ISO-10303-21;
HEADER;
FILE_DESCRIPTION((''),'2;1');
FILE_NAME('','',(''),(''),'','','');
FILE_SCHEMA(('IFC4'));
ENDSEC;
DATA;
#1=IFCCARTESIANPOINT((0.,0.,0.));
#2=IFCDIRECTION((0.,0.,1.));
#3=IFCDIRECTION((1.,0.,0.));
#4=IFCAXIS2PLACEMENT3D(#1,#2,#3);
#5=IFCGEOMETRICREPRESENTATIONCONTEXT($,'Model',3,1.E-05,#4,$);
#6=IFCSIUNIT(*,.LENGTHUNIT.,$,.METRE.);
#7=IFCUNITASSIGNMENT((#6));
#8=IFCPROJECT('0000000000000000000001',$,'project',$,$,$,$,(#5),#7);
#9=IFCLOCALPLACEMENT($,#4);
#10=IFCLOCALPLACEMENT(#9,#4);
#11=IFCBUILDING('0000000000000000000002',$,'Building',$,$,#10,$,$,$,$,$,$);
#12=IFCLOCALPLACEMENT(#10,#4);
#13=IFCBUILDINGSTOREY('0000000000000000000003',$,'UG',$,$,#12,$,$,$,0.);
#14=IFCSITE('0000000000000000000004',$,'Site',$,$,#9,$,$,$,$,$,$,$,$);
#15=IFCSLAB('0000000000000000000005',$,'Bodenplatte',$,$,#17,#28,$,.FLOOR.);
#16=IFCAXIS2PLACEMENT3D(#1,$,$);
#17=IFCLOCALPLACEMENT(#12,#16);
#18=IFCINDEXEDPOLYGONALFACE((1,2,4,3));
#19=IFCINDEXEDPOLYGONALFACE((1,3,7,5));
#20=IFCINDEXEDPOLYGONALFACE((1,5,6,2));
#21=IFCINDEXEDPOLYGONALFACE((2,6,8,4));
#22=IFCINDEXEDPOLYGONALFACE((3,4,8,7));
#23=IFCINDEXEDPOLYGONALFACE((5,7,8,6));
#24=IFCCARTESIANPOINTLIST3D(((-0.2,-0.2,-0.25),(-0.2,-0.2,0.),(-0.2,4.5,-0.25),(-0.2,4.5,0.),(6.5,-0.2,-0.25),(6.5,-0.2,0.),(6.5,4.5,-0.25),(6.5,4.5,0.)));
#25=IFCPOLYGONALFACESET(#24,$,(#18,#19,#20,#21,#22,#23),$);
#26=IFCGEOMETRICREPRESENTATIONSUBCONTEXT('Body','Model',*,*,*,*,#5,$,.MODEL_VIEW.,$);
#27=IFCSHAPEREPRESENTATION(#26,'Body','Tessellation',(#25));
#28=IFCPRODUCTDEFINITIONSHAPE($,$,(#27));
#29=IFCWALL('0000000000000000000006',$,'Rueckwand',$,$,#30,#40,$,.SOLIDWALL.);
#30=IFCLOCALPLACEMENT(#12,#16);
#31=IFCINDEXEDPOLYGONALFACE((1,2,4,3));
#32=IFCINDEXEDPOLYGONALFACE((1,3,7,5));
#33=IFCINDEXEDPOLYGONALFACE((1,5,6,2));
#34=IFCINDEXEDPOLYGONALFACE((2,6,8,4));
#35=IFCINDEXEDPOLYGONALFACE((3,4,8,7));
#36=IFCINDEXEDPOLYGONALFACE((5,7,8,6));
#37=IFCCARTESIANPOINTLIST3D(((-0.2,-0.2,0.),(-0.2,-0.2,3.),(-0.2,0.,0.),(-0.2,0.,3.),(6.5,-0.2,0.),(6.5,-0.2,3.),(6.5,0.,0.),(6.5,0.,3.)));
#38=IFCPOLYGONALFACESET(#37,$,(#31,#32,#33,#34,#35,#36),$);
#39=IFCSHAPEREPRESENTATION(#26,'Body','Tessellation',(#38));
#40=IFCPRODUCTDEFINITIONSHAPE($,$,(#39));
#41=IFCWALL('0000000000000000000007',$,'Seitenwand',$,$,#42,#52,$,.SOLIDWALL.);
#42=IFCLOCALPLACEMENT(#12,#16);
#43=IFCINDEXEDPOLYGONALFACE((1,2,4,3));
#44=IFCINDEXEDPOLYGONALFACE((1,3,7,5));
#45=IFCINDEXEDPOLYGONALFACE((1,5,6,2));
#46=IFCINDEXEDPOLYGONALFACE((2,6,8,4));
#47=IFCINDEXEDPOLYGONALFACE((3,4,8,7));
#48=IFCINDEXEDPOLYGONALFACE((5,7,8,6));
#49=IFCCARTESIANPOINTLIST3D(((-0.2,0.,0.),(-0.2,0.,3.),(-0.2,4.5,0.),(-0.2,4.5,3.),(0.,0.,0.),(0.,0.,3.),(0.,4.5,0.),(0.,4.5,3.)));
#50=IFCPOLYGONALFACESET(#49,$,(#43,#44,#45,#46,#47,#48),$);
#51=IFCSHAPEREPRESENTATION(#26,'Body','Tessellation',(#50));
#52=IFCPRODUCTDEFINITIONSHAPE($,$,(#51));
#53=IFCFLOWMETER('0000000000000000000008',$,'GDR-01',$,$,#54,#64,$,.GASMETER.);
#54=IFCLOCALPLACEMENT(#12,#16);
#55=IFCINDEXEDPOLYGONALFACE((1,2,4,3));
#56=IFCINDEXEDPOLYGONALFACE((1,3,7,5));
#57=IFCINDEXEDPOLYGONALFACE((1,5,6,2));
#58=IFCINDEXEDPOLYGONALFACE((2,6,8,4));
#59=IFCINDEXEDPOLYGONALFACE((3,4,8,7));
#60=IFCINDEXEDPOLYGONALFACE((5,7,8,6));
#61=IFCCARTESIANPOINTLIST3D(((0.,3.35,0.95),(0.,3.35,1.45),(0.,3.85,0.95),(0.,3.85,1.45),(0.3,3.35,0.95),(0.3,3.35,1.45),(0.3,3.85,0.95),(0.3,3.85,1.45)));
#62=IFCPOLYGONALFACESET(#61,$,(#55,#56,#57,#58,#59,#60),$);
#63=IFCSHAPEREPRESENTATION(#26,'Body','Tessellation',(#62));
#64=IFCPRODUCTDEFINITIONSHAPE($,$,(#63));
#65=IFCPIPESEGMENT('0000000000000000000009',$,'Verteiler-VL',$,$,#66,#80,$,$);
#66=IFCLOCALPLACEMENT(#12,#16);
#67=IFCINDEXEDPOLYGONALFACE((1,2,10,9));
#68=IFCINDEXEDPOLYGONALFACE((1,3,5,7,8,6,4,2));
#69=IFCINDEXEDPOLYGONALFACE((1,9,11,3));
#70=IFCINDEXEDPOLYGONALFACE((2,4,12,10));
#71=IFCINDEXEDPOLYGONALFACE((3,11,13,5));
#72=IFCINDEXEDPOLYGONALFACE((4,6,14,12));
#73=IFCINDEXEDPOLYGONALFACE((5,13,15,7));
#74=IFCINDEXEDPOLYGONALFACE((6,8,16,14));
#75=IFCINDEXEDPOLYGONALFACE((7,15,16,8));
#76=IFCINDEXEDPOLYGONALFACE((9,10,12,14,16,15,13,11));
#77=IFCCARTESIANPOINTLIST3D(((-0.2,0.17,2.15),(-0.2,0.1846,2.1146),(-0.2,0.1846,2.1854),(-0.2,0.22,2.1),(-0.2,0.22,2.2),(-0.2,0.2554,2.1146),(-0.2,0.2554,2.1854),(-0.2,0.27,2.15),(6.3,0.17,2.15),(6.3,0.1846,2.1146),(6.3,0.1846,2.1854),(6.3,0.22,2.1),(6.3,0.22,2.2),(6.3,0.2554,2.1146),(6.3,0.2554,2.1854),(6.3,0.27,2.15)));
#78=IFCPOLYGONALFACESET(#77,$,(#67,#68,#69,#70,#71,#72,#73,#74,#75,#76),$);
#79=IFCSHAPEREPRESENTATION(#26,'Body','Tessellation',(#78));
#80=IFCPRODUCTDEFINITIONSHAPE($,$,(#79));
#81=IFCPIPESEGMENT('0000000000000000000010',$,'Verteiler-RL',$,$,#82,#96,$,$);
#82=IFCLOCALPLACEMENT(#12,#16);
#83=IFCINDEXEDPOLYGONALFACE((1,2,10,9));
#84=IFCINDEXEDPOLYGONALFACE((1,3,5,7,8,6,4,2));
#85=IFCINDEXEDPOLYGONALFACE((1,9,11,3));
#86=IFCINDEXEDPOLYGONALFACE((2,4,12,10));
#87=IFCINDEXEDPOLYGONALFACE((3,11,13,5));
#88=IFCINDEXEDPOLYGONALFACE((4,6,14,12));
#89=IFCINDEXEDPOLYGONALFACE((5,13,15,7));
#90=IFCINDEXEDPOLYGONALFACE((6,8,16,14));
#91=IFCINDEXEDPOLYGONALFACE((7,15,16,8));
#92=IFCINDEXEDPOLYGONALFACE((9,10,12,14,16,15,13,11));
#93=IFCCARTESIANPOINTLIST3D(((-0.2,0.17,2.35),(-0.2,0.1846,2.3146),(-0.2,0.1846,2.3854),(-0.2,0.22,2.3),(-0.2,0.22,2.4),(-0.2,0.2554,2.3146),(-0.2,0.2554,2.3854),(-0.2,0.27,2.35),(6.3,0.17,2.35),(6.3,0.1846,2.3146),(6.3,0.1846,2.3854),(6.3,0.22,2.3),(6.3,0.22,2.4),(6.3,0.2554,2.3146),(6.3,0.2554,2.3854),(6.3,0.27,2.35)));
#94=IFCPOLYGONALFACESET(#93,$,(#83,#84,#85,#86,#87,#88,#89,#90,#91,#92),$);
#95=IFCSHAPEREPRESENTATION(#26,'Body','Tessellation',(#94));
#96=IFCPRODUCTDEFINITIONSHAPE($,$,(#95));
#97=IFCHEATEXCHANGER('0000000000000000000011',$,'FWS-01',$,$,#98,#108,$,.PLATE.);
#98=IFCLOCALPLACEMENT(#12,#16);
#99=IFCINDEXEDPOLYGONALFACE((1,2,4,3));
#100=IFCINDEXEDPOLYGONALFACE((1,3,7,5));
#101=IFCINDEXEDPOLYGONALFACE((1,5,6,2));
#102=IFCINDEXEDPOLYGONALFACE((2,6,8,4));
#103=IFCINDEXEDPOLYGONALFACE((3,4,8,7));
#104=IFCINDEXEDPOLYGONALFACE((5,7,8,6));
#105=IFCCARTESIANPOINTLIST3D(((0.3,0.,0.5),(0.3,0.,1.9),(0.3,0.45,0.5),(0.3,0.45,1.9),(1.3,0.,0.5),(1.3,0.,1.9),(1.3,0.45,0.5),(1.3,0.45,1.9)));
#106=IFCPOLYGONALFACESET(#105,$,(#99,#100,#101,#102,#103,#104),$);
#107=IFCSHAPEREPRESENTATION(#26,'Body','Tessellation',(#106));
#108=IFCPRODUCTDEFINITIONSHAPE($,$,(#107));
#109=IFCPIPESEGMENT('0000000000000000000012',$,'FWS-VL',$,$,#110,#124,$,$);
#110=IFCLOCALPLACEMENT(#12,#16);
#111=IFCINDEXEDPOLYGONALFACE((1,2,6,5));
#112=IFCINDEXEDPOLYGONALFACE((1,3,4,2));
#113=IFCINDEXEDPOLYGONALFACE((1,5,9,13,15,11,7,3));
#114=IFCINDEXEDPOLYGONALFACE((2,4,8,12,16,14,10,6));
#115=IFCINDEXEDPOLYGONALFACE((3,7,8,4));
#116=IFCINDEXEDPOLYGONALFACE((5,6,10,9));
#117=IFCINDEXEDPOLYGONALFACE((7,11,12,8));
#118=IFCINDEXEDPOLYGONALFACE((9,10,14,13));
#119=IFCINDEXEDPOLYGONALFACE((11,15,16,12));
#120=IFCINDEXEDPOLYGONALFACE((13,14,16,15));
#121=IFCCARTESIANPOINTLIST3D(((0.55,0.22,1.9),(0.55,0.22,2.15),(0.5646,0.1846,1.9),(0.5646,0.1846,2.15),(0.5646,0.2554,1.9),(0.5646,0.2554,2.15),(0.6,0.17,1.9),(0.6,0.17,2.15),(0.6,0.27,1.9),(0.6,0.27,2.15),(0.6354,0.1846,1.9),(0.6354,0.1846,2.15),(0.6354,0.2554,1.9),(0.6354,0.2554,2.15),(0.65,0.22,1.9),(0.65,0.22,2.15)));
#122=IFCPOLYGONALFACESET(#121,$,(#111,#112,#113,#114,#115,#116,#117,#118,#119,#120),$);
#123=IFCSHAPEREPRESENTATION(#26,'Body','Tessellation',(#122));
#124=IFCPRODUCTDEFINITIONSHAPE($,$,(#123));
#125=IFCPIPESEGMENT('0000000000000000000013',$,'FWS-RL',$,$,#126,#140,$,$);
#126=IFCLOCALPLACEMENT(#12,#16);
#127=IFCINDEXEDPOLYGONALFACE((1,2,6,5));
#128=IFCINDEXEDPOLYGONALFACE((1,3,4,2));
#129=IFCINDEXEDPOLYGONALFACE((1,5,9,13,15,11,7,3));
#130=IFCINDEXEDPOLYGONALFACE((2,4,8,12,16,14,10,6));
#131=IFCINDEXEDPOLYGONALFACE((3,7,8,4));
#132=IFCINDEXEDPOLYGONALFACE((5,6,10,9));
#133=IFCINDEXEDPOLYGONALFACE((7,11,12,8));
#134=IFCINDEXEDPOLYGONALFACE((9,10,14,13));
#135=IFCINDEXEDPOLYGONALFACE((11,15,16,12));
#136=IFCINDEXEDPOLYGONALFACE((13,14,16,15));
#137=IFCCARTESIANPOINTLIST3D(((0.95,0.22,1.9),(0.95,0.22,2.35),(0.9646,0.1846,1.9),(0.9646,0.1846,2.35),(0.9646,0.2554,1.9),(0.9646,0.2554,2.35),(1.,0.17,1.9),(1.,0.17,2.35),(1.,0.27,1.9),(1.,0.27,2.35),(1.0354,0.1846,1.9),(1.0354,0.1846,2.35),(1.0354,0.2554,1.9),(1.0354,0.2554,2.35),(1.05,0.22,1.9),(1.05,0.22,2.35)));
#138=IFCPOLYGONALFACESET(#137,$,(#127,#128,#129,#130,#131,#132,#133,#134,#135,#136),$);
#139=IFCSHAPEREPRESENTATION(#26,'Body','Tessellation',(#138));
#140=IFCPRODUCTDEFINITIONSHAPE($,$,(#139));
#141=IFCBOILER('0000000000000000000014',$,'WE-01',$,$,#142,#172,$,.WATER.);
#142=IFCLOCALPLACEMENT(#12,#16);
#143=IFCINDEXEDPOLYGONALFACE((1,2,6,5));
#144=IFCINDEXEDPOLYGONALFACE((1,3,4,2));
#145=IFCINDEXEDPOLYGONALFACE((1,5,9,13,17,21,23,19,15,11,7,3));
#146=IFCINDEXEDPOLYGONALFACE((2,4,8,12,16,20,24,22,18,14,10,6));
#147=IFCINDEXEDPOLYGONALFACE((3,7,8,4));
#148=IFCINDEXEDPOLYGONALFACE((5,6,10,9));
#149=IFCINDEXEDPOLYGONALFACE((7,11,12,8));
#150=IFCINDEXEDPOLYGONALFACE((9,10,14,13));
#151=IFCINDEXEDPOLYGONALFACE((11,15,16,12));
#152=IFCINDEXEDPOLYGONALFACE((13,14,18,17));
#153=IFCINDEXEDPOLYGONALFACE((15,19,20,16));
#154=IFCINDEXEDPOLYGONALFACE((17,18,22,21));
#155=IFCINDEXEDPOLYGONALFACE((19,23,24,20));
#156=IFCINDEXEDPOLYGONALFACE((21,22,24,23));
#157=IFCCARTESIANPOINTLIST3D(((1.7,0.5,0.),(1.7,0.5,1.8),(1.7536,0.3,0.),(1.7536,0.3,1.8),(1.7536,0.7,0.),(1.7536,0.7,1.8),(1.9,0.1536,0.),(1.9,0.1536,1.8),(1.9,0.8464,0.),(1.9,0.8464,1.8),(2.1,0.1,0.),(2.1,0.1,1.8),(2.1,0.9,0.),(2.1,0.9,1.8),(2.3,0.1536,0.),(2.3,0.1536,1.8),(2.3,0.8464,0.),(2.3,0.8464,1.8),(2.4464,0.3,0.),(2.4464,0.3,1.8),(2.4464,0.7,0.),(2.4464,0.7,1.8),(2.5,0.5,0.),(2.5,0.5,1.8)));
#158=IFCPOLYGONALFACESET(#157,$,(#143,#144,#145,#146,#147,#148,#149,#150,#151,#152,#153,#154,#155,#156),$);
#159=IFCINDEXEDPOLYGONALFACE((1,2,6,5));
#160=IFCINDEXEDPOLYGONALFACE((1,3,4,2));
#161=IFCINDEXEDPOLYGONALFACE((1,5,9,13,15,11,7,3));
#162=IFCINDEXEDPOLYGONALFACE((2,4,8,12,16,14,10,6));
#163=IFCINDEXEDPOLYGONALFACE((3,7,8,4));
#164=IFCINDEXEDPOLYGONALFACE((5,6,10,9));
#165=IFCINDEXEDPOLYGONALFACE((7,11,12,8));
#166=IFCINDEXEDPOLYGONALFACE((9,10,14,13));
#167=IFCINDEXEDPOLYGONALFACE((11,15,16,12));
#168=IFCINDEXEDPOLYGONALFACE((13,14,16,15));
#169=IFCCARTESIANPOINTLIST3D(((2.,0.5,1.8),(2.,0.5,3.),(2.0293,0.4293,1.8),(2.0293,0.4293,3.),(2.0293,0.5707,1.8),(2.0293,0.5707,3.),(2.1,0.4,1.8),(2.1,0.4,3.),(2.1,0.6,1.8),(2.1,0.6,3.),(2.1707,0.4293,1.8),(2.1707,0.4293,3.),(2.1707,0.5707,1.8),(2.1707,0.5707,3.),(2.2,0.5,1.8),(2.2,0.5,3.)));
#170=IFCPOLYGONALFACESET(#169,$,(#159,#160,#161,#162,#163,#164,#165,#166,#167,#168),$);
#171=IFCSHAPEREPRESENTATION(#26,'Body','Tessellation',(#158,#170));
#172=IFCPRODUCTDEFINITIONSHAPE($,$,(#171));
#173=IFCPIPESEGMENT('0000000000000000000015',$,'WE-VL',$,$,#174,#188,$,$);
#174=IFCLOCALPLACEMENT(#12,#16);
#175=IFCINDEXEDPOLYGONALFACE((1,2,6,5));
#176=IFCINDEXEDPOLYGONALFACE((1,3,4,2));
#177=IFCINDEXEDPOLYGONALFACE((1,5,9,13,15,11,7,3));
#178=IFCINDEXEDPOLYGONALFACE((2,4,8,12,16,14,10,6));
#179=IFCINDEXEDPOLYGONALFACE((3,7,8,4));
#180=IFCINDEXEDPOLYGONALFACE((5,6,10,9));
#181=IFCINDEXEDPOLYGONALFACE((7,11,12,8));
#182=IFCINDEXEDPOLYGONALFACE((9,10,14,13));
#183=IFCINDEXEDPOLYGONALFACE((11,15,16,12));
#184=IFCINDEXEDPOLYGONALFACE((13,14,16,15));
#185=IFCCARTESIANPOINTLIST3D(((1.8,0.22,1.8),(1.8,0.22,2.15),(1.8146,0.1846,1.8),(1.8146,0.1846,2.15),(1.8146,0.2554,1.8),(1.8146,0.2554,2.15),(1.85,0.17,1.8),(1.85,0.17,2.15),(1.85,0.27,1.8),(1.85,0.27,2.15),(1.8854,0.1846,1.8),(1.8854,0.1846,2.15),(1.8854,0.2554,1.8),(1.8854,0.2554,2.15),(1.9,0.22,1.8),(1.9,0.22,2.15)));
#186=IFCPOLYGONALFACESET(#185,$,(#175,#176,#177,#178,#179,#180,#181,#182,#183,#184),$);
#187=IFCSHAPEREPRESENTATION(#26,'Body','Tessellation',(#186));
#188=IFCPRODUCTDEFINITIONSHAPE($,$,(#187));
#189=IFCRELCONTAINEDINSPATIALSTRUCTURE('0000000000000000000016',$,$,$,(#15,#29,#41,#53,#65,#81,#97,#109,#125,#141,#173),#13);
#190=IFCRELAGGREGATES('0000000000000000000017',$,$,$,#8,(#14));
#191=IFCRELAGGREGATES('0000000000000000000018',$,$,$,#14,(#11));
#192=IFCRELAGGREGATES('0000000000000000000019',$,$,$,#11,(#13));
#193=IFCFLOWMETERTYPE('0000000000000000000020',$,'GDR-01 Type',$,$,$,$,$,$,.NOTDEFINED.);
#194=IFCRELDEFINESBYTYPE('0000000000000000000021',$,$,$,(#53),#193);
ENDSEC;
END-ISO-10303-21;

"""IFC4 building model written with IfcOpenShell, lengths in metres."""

from ifc_helpers import new_model, si_unit, frame, origin_with_axes, place, context, subcontext, project, spatial, polyline, outline, extrude, type_object, element, save


model = new_model("IFC4")

# Units and contexts
model_context = context("Model", 3, precision=1e-05, world=origin_with_axes())
body_context = subcontext(model_context, "Body", "Model", "MODEL_VIEW")
ifc_project = project(units=[si_unit("LENGTHUNIT", "METRE")], contexts=[model_context])

# Site, building, storey
site_placement = place(None, origin_with_axes())
site = spatial("IfcSite", under=ifc_project, at=site_placement, Name="Site")
building_placement = place(site_placement, origin_with_axes())
building = spatial("IfcBuilding", under=site, at=building_placement, Name="Building")
storey_placement = place(building_placement, origin_with_axes())
storey = spatial("IfcBuildingStorey", under=building, at=storey_placement, Name="UG", Elevation=0.0)

# Slab
slab_placement = place(storey_placement, frame((0.0, 0.0, -0.25), z_axis=(0.0, 0.0, 1.0), x_axis=(1.0, 0.0, 0.0)))
element("IfcSlab", 1, at=slab_placement, inside=storey, Name="Bodenplatte", PredefinedType="FLOOR", context=body_context, shape_type="SweptSolid", body=[
    extrude(outline(polyline([(-0.2, -0.2, 0.0), (6.5, -0.2, 0.0), (6.5, 4.5, 0.0), (-0.2, 4.5, 0.0), (-0.2, -0.2, 0.0)])), origin_with_axes(), (0.0, 0.0, 1.0), 0.25),
])

# Walls
wall_1_placement = place(storey_placement, frame((-0.2, -0.2, 0.0), z_axis=(0.0, 0.0, 1.0), x_axis=(1.0, 0.0, 0.0)))
element("IfcWall", 2, at=wall_1_placement, inside=storey, Name="Rueckwand", PredefinedType="SOLIDWALL", context=body_context, shape_type="SweptSolid", body=[
    extrude(outline(polyline([(0.0, 0.0, 0.0), (6.7, 0.0, 0.0), (6.7, 0.2, 0.0), (0.0, 0.2, 0.0), (0.0, 0.0, 0.0)])), origin_with_axes(), (0.0, 0.0, 1.0), 3.0),
])
wall_2_placement = place(storey_placement, frame((0.0, 0.0, 0.0), z_axis=(0.0, 0.0, 1.0), x_axis=(0.0, 1.0, 0.0)))
element("IfcWall", 3, at=wall_2_placement, inside=storey, Name="Seitenwand", PredefinedType="SOLIDWALL", context=body_context, shape_type="SweptSolid", body=[
    extrude(outline(polyline([(0.0, 0.0, 0.0), (4.5, 0.0, 0.0), (4.5, 0.2, 0.0), (0.0, 0.2, 0.0), (0.0, 0.0, 0.0)])), origin_with_axes(), (0.0, 0.0, 1.0), 3.0),
])

# Flow meter
flow_meter_type = type_object("IfcFlowMeterType", Name="GDR-01 Type", PredefinedType="NOTDEFINED")
flow_meter_placement = place(storey_placement, origin_with_axes())
element("IfcFlowMeter", 4, at=flow_meter_placement, inside=storey, type_object=flow_meter_type, Name="GDR-01", PredefinedType="GASMETER", context=body_context, shape_type="SweptSolid", body=[
    extrude(outline(polyline([(0.0, 3.35, 0.0), (0.3, 3.35, 0.0), (0.3, 3.85, 0.0), (0.0, 3.85, 0.0), (0.0, 3.35, 0.0)])), frame((0.0, 0.0, 0.95), z_axis=(0.0, 0.0, 1.0), x_axis=(1.0, 0.0, 0.0)), (0.0, 0.0, 1.0), 0.5),
])

# Pipe segments
pipe_segment_1_placement = place(storey_placement, origin_with_axes())
element("IfcPipeSegment", 5, at=pipe_segment_1_placement, inside=storey, Name="Verteiler-VL", context=body_context, shape_type="SweptSolid", body=[
    extrude(outline(polyline([(0.05, 0.0, 0.0), (0.0354, 0.0354, 0.0), (0.0, 0.05, 0.0), (-0.0354, 0.0354, 0.0), (-0.05, 0.0, 0.0), (-0.0354, -0.0354, 0.0), (0.0, -0.05, 0.0), (0.0354, -0.0354, 0.0), (0.05, 0.0, 0.0)])), frame((-0.2, 0.22, 2.15), z_axis=(1.0, 0.0, 0.0), x_axis=(0.0, 1.0, 0.0)), (0.0, 0.0, 1.0), 6.5),
])
pipe_segment_2_placement = place(storey_placement, origin_with_axes())
element("IfcPipeSegment", 6, at=pipe_segment_2_placement, inside=storey, Name="Verteiler-RL", context=body_context, shape_type="SweptSolid", body=[
    extrude(outline(polyline([(0.05, 0.0, 0.0), (0.0354, 0.0354, 0.0), (0.0, 0.05, 0.0), (-0.0354, 0.0354, 0.0), (-0.05, 0.0, 0.0), (-0.0354, -0.0354, 0.0), (0.0, -0.05, 0.0), (0.0354, -0.0354, 0.0), (0.05, 0.0, 0.0)])), frame((-0.2, 0.22, 2.35), z_axis=(1.0, 0.0, 0.0), x_axis=(0.0, 1.0, 0.0)), (0.0, 0.0, 1.0), 6.5),
])

# Heat exchanger
heat_exchanger_placement = place(storey_placement, origin_with_axes())
element("IfcHeatExchanger", 7, at=heat_exchanger_placement, inside=storey, Name="FWS-01", PredefinedType="PLATE", context=body_context, shape_type="SweptSolid", body=[
    extrude(outline(polyline([(0.3, 0.0, 0.0), (1.3, 0.0, 0.0), (1.3, 0.45, 0.0), (0.3, 0.45, 0.0), (0.3, 0.0, 0.0)])), frame((0.0, 0.0, 0.5), z_axis=(0.0, 0.0, 1.0), x_axis=(1.0, 0.0, 0.0)), (0.0, 0.0, 1.0), 1.4),
])

# Pipe segments
pipe_segment_3_placement = place(storey_placement, origin_with_axes())
element("IfcPipeSegment", 8, at=pipe_segment_3_placement, inside=storey, Name="FWS-VL", context=body_context, shape_type="SweptSolid", body=[
    extrude(outline(polyline([(0.05, 0.0, 0.0), (0.0354, 0.0354, 0.0), (0.0, 0.05, 0.0), (-0.0354, 0.0354, 0.0), (-0.05, 0.0, 0.0), (-0.0354, -0.0354, 0.0), (0.0, -0.05, 0.0), (0.0354, -0.0354, 0.0), (0.05, 0.0, 0.0)])), frame((0.6, 0.22, 1.9), z_axis=(0.0, 0.0, 1.0), x_axis=(1.0, 0.0, 0.0)), (0.0, 0.0, 1.0), 0.25),
])
pipe_segment_4_placement = place(storey_placement, origin_with_axes())
element("IfcPipeSegment", 9, at=pipe_segment_4_placement, inside=storey, Name="FWS-RL", context=body_context, shape_type="SweptSolid", body=[
    extrude(outline(polyline([(0.05, 0.0, 0.0), (0.0354, 0.0354, 0.0), (0.0, 0.05, 0.0), (-0.0354, 0.0354, 0.0), (-0.05, 0.0, 0.0), (-0.0354, -0.0354, 0.0), (0.0, -0.05, 0.0), (0.0354, -0.0354, 0.0), (0.05, 0.0, 0.0)])), frame((1.0, 0.22, 1.9), z_axis=(0.0, 0.0, 1.0), x_axis=(1.0, 0.0, 0.0)), (0.0, 0.0, 1.0), 0.45),
])

# Boiler
boiler_placement = place(storey_placement, origin_with_axes())
element("IfcBoiler", 10, at=boiler_placement, inside=storey, Name="WE-01", PredefinedType="WATER", context=body_context, shape_type="SweptSolid", body=[
    extrude(outline(polyline([(0.4, 0.0, 0.0), (0.3464, 0.2, 0.0), (0.2, 0.3464, 0.0), (0.0, 0.4, 0.0), (-0.2, 0.3464, 0.0), (-0.3464, 0.2, 0.0), (-0.4, 0.0, 0.0), (-0.3464, -0.2, 0.0), (-0.2, -0.3464, 0.0), (0.0, -0.4, 0.0), (0.2, -0.3464, 0.0), (0.3464, -0.2, 0.0), (0.4, 0.0, 0.0)])), frame((2.1, 0.5, 0.0), z_axis=(0.0, 0.0, 1.0), x_axis=(1.0, 0.0, 0.0)), (0.0, 0.0, 1.0), 1.8),
    extrude(outline(polyline([(0.1, 0.0, 0.0), (0.0707, 0.0707, 0.0), (0.0, 0.1, 0.0), (-0.0707, 0.0707, 0.0), (-0.1, 0.0, 0.0), (-0.0707, -0.0707, 0.0), (0.0, -0.1, 0.0), (0.0707, -0.0707, 0.0), (0.1, 0.0, 0.0)])), frame((2.1, 0.5, 1.8), z_axis=(0.0, 0.0, 1.0), x_axis=(1.0, 0.0, 0.0)), (0.0, 0.0, 1.0), 1.2),
])

# Pipe segment
pipe_segment_5_placement = place(storey_placement, origin_with_axes())
element("IfcPipeSegment", 11, at=pipe_segment_5_placement, inside=storey, Name="WE-VL", context=body_context, shape_type="SweptSolid", body=[
    extrude(outline(polyline([(0.05, 0.0, 0.0), (0.0354, 0.0354, 0.0), (0.0, 0.05, 0.0), (-0.0354, 0.0354, 0.0), (-0.05, 0.0, 0.0), (-0.0354, -0.0354, 0.0), (0.0, -0.05, 0.0), (0.0354, -0.0354, 0.0), (0.05, 0.0, 0.0)])), frame((1.85, 0.22, 1.8), z_axis=(0.0, 0.0, 1.0), x_axis=(1.0, 0.0, 0.0)), (0.0, 0.0, 1.0), 0.35),
])

save(model, "model.ifc")
